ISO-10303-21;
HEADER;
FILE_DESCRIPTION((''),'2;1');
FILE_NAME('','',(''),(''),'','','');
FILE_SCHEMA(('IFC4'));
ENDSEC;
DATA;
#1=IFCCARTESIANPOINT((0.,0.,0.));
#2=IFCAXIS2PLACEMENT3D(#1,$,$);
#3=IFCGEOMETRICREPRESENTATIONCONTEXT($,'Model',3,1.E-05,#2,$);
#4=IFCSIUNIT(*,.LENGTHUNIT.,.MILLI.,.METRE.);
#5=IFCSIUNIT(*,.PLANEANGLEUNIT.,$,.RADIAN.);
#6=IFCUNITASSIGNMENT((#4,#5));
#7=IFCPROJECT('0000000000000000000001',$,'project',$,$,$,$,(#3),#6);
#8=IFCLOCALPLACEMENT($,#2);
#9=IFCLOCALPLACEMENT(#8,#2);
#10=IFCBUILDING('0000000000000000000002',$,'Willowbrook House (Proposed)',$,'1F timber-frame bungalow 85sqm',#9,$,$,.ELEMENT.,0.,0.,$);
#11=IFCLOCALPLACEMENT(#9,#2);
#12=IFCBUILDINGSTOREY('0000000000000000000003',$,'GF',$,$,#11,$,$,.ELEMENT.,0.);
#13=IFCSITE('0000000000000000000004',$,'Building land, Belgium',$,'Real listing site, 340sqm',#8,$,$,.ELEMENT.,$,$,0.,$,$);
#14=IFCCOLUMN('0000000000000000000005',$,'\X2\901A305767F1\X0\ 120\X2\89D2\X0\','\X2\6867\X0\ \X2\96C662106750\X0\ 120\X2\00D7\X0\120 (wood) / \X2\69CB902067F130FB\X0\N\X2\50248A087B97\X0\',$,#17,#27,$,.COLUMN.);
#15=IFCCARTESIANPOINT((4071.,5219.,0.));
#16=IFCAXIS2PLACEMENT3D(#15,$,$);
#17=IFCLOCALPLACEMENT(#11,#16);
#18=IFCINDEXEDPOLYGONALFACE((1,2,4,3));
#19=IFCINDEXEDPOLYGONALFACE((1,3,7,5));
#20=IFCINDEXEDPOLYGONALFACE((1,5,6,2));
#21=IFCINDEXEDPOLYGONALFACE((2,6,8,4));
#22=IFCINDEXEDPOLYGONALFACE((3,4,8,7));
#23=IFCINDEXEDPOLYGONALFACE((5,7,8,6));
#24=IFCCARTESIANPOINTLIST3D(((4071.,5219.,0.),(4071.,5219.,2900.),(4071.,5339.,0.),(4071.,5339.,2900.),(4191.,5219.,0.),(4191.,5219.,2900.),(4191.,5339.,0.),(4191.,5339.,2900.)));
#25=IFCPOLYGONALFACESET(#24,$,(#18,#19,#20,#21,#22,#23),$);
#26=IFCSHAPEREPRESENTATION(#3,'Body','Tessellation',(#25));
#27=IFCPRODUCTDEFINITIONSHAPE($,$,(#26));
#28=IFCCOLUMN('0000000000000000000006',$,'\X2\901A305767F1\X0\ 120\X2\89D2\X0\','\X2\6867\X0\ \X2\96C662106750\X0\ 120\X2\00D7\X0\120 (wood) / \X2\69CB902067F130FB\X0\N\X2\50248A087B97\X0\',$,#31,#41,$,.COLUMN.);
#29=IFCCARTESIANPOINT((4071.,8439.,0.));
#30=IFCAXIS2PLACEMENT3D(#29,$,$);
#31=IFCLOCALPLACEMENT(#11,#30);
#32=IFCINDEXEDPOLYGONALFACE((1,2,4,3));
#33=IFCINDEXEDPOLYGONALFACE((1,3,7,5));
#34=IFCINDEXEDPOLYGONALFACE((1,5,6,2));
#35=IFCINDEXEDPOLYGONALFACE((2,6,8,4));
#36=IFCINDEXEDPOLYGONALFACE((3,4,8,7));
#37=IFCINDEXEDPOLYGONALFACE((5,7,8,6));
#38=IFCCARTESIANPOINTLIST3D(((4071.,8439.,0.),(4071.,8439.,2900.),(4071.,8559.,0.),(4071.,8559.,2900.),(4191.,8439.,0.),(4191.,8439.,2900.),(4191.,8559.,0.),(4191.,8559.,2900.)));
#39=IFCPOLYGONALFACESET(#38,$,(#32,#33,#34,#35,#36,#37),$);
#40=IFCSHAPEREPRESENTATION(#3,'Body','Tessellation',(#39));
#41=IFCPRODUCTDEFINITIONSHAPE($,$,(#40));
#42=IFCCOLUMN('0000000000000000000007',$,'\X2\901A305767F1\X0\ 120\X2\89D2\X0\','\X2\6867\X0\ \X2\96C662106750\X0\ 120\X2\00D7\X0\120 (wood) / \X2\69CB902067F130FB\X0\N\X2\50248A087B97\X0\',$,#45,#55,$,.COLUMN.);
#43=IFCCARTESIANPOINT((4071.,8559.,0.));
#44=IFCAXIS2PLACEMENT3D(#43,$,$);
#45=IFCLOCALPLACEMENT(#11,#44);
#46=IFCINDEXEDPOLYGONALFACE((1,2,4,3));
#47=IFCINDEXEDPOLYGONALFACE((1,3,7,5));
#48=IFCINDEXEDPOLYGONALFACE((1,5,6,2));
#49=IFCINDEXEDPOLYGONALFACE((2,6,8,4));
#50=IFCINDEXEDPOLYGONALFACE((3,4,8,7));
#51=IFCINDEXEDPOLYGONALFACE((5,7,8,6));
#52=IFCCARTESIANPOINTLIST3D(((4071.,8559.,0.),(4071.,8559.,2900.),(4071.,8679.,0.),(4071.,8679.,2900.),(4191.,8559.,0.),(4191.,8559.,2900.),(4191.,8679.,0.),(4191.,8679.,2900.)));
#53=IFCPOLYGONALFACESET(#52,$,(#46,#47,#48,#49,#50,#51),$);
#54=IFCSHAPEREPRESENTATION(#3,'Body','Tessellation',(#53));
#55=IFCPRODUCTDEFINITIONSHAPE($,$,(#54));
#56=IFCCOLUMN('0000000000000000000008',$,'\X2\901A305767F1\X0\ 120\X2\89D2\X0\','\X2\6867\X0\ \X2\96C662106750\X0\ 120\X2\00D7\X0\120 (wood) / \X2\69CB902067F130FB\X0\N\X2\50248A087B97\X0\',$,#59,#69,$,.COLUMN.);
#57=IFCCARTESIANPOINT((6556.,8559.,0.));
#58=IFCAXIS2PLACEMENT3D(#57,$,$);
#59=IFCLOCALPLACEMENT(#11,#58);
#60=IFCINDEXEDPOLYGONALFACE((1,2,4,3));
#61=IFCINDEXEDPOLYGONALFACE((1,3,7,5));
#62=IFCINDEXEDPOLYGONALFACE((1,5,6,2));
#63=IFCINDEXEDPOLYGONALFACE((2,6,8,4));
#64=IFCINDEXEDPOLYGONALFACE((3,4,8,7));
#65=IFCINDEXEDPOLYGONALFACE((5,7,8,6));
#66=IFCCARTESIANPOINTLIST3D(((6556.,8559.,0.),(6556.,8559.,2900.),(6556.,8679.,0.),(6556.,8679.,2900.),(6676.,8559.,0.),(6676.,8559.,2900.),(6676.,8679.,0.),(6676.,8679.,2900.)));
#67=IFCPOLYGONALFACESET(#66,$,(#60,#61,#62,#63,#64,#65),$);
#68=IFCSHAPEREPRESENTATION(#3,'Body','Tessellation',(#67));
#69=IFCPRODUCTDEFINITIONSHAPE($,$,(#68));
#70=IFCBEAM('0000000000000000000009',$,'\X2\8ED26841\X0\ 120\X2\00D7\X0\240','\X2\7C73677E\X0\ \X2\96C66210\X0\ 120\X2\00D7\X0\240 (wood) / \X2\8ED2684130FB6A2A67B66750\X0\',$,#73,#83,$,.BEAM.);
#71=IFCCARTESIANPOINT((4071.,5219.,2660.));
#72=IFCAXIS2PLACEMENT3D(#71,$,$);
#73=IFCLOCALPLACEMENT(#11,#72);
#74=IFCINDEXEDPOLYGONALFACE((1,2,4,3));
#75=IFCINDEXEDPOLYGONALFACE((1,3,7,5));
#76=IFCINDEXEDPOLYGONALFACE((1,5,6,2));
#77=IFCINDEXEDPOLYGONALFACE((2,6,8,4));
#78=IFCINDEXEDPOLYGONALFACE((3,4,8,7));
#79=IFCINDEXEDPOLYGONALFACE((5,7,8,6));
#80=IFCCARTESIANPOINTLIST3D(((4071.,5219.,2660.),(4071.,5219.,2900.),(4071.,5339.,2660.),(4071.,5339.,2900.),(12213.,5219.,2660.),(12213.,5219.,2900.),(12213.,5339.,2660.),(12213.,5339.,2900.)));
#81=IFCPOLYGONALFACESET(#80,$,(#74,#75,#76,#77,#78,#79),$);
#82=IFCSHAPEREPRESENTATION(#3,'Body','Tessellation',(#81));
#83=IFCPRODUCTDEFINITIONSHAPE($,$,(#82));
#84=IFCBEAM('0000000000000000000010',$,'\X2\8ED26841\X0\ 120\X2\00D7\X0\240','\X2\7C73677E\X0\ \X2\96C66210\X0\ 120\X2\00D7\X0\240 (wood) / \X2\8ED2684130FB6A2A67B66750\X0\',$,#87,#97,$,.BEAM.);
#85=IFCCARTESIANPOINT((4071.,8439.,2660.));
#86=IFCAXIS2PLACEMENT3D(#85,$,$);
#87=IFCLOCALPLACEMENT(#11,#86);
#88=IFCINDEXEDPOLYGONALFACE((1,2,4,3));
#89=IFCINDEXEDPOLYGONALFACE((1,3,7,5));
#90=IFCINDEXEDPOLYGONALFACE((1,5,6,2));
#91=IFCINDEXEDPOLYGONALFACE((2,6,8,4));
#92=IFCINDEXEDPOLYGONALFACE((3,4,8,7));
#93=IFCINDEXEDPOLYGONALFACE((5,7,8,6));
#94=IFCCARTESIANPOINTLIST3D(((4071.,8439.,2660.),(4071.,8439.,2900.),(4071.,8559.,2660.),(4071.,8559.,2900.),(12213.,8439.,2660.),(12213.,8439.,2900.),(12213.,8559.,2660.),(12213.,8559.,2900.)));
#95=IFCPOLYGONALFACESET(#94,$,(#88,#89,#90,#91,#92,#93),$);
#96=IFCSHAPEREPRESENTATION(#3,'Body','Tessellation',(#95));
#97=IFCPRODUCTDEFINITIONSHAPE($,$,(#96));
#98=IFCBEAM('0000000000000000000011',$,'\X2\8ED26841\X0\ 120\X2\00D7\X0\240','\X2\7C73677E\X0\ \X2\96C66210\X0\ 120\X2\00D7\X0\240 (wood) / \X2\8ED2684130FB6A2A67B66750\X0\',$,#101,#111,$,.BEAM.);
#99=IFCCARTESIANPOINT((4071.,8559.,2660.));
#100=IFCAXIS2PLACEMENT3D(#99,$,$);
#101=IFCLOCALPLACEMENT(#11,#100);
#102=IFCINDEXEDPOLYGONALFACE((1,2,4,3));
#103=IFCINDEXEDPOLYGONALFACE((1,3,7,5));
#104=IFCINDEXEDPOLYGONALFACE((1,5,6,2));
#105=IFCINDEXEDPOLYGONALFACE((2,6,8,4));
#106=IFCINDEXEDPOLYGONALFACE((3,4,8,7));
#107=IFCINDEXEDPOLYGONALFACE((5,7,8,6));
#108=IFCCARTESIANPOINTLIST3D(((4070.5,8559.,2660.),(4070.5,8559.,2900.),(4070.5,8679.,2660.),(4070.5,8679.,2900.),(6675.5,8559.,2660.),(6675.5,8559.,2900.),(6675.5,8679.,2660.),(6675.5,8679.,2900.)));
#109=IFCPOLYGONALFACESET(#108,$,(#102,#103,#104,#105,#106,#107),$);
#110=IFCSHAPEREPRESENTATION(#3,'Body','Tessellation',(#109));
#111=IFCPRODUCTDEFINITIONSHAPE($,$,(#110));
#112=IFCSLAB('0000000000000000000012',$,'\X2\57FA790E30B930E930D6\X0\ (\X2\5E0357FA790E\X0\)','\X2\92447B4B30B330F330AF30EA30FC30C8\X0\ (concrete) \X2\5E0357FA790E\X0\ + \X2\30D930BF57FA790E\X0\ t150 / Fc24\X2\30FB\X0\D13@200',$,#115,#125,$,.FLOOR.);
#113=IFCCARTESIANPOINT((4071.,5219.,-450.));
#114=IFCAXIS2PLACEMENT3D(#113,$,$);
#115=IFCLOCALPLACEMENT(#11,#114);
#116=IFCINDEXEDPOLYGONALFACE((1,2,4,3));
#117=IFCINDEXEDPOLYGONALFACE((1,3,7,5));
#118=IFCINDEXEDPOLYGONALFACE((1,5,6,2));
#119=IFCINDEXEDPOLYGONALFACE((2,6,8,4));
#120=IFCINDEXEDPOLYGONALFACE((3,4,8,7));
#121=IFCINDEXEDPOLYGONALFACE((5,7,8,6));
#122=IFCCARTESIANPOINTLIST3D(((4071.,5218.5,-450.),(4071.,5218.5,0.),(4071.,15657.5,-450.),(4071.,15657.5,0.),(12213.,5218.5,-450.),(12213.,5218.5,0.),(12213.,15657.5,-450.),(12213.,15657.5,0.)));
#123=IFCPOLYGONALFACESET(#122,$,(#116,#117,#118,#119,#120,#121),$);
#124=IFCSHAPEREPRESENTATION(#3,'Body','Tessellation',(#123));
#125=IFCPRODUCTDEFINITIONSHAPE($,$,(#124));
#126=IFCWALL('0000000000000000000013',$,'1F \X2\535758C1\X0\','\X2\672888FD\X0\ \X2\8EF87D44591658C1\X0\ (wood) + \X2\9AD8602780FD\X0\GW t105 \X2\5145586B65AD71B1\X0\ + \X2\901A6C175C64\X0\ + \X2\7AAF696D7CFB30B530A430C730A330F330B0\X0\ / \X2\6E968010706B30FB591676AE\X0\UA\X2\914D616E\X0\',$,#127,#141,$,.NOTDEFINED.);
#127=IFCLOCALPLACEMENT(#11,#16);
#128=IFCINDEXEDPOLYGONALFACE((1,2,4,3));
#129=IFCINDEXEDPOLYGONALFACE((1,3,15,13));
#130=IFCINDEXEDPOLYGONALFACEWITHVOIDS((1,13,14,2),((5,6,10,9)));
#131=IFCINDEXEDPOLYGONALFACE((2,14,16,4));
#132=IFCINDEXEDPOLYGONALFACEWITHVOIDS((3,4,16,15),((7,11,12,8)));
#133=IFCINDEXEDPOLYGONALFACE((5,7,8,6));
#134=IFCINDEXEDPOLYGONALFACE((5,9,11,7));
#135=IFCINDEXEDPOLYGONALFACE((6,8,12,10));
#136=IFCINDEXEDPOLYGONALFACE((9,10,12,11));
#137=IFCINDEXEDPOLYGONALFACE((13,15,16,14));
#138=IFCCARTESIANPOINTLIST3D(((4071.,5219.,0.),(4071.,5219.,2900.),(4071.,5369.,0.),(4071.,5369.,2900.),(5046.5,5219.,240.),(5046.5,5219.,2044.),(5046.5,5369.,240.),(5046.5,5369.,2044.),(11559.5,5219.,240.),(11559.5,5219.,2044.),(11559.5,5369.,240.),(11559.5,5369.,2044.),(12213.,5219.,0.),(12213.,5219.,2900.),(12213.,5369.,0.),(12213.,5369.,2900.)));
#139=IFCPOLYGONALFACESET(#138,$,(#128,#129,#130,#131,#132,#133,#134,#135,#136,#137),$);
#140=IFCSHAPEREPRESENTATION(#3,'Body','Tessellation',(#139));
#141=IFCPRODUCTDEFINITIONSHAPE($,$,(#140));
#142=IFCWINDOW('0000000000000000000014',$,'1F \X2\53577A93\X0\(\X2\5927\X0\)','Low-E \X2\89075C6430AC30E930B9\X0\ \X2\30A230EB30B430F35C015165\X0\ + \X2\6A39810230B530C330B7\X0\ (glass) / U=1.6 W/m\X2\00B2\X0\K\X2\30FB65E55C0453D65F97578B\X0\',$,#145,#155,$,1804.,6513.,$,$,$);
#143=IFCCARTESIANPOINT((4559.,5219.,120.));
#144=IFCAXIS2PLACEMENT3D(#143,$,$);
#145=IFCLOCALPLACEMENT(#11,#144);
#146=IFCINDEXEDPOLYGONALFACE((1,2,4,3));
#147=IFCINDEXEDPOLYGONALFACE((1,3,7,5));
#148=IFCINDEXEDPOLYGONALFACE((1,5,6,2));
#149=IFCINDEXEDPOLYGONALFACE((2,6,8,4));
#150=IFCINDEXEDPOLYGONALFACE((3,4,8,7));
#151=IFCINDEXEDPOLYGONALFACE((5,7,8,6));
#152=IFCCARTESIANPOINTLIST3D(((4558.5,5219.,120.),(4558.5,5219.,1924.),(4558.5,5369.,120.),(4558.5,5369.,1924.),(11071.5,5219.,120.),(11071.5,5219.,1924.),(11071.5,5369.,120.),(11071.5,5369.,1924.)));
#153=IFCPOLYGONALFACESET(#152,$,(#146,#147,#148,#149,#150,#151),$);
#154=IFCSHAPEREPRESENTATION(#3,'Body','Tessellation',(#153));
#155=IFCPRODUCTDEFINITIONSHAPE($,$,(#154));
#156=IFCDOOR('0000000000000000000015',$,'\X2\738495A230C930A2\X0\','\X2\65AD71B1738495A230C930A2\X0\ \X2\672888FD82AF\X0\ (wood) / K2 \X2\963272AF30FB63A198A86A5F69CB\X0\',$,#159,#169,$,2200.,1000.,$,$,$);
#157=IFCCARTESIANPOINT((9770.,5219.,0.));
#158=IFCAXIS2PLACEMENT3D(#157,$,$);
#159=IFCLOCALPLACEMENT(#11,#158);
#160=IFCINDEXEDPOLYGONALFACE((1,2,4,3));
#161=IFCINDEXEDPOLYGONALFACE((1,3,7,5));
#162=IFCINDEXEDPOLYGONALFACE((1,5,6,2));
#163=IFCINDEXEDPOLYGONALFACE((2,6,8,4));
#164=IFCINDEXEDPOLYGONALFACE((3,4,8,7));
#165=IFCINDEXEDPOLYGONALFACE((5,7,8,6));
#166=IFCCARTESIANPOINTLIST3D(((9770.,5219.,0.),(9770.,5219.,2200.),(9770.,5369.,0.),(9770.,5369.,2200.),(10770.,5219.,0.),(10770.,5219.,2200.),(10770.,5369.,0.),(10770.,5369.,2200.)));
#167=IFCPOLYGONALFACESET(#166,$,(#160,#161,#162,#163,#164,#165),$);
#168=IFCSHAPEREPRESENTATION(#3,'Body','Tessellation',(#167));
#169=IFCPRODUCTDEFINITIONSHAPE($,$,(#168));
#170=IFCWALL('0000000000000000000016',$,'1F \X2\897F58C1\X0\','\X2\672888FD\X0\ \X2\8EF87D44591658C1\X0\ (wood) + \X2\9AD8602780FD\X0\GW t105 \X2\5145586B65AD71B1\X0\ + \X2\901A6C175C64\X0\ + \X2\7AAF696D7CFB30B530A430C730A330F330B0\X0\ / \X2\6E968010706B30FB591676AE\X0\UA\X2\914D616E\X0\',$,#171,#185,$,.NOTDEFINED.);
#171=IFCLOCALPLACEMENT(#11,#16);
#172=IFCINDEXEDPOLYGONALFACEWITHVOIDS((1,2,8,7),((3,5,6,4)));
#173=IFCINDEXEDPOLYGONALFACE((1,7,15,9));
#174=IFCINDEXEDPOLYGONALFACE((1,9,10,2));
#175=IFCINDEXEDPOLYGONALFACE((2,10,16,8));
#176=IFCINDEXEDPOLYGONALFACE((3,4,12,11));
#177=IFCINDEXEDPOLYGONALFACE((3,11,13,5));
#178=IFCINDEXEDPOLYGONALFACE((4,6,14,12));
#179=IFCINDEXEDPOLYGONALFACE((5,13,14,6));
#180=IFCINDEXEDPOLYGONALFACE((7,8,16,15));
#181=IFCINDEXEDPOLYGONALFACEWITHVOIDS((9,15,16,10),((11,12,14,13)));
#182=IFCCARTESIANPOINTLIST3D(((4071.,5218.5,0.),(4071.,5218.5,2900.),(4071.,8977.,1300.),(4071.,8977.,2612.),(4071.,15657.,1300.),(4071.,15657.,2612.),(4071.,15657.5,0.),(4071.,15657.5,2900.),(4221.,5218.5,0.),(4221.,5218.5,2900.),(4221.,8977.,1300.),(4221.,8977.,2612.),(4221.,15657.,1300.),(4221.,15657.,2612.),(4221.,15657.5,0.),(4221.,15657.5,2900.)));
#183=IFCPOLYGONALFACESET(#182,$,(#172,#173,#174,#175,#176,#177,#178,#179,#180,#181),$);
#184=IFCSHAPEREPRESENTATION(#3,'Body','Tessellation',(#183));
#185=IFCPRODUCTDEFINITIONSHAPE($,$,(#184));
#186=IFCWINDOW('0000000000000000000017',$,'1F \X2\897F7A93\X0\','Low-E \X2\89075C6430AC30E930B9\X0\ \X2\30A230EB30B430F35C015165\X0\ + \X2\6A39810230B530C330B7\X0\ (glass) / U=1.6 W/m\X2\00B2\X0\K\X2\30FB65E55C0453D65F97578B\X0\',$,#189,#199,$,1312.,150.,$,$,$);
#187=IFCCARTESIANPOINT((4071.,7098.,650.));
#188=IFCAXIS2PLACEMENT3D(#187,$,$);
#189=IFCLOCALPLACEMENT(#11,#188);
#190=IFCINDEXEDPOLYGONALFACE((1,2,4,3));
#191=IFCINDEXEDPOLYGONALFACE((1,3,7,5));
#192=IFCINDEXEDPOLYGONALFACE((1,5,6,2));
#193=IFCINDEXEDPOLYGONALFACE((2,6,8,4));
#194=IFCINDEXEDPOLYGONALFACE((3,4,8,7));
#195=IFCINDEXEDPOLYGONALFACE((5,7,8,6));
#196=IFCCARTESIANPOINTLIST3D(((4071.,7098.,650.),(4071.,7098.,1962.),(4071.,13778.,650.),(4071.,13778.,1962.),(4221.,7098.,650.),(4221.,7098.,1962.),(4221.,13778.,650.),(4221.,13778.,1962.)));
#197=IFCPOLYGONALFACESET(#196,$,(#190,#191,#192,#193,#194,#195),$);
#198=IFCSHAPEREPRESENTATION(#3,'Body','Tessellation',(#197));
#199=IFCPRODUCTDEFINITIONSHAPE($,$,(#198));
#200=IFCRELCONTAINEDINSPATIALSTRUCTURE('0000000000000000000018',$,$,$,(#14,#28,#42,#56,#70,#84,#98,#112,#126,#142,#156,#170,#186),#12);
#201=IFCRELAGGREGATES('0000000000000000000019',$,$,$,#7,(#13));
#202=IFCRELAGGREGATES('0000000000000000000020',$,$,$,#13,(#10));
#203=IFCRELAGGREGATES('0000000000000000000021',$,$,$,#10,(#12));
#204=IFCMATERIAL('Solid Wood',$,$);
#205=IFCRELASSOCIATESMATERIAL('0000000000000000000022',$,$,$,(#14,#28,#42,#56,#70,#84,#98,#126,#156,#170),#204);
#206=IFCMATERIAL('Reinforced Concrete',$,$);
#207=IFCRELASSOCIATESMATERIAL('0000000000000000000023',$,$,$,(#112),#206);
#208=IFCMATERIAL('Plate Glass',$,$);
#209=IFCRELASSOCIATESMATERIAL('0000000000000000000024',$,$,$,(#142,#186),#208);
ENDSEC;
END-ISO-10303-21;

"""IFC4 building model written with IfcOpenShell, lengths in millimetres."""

from ifc_helpers import new_model, si_unit, frame, frame_2d, origin, place, context, project, spatial, rectangle, extrude, material, element, fill, save


model = new_model("IFC4")

# Units and contexts
model_context = context("Model", 3, precision=1e-05, world=origin())
ifc_project = project(units=[si_unit("LENGTHUNIT", "METRE", prefix="MILLI"), si_unit("PLANEANGLEUNIT", "RADIAN")], contexts=[model_context])

# Site, building, storey
site_placement = place(None, origin())
site = spatial("IfcSite", under=ifc_project, at=site_placement, Name="Building land, Belgium", ObjectType="Real listing site, 340sqm", CompositionType="ELEMENT", RefElevation=0.0)
building_placement = place(site_placement, origin())
building = spatial("IfcBuilding", under=site, at=building_placement, Name="Willowbrook House (Proposed)", ObjectType="1F timber-frame bungalow 85sqm", CompositionType="ELEMENT", ElevationOfRefHeight=0.0, ElevationOfTerrain=0.0)
storey_placement = place(building_placement, origin())
storey = spatial("IfcBuildingStorey", under=building, at=storey_placement, Name="GF", CompositionType="ELEMENT", Elevation=0.0)

# Columns
ifc_material_1 = material(Name="Solid Wood")
column_1_placement = place(storey_placement, frame((4071.0, 5219.0, 0.0)))
element("IfcColumn", 1, at=column_1_placement, inside=storey, material=ifc_material_1, Name="通し柱 120角", Description="桧 集成材 120×120 (wood) / 構造柱・N値計算", PredefinedType="COLUMN", context=model_context, shape_type="SweptSolid", body=[
    extrude(rectangle(XDim=120.0, YDim=120.0, at=frame_2d((60.0, 60.0))), frame((4071.0, 5219.0, 0.0)), (0.0, 0.0, 1.0), 2900.0),
])
column_2_placement = place(storey_placement, frame((4071.0, 8439.0, 0.0)))
element("IfcColumn", 2, at=column_2_placement, inside=storey, material=ifc_material_1, Name="通し柱 120角", Description="桧 集成材 120×120 (wood) / 構造柱・N値計算", PredefinedType="COLUMN", context=model_context, shape_type="SweptSolid", body=[
    extrude(rectangle(XDim=120.0, YDim=120.0, at=frame_2d((60.0, 60.0))), frame((4071.0, 8439.0, 0.0)), (0.0, 0.0, 1.0), 2900.0),
])
column_3_placement = place(storey_placement, frame((4071.0, 8559.0, 0.0)))
element("IfcColumn", 3, at=column_3_placement, inside=storey, material=ifc_material_1, Name="通し柱 120角", Description="桧 集成材 120×120 (wood) / 構造柱・N値計算", PredefinedType="COLUMN", context=model_context, shape_type="SweptSolid", body=[
    extrude(rectangle(XDim=120.0, YDim=120.0, at=frame_2d((60.0, 60.0))), frame((4071.0, 8559.0, 0.0)), (0.0, 0.0, 1.0), 2900.0),
])
column_4_placement = place(storey_placement, frame((6556.0, 8559.0, 0.0)))
element("IfcColumn", 4, at=column_4_placement, inside=storey, material=ifc_material_1, Name="通し柱 120角", Description="桧 集成材 120×120 (wood) / 構造柱・N値計算", PredefinedType="COLUMN", context=model_context, shape_type="SweptSolid", body=[
    extrude(rectangle(XDim=120.0, YDim=120.0, at=frame_2d((60.0, 60.0))), frame((6556.0, 8559.0, 0.0)), (0.0, 0.0, 1.0), 2900.0),
])

# Beams
beam_1_placement = place(storey_placement, frame((4071.0, 5219.0, 2660.0)))
element("IfcBeam", 5, at=beam_1_placement, inside=storey, material=ifc_material_1, Name="軒桁 120×240", Description="米松 集成 120×240 (wood) / 軒桁・横架材", PredefinedType="BEAM", context=model_context, shape_type="SweptSolid", body=[
    extrude(rectangle(XDim=8142.0, YDim=120.0, at=frame_2d((4071.0, 60.0))), frame((4071.0, 5219.0, 2660.0)), (0.0, 0.0, 1.0), 240.0),
])
beam_2_placement = place(storey_placement, frame((4071.0, 8439.0, 2660.0)))
element("IfcBeam", 6, at=beam_2_placement, inside=storey, material=ifc_material_1, Name="軒桁 120×240", Description="米松 集成 120×240 (wood) / 軒桁・横架材", PredefinedType="BEAM", context=model_context, shape_type="SweptSolid", body=[
    extrude(rectangle(XDim=8142.0, YDim=120.0, at=frame_2d((4071.0, 60.0))), frame((4071.0, 8439.0, 2660.0)), (0.0, 0.0, 1.0), 240.0),
])
beam_3_placement = place(storey_placement, frame((4071.0, 8559.0, 2660.0)))
element("IfcBeam", 7, at=beam_3_placement, inside=storey, material=ifc_material_1, Name="軒桁 120×240", Description="米松 集成 120×240 (wood) / 軒桁・横架材", PredefinedType="BEAM", context=model_context, shape_type="SweptSolid", body=[
    extrude(rectangle(XDim=2605.0, YDim=120.0, at=frame_2d((1302.0, 60.0))), frame((4071.0, 8559.0, 2660.0)), (0.0, 0.0, 1.0), 240.0),
])

# Slab
ifc_material_2 = material(Name="Reinforced Concrete")
slab_1_placement = place(storey_placement, frame((4071.0, 5219.0, -450.0)))
element("IfcSlab", 8, at=slab_1_placement, inside=storey, material=ifc_material_2, Name="基礎スラブ (布基礎)", Description="鉄筋コンクリート (concrete) 布基礎 + ベタ基礎 t150 / Fc24・D13@200", PredefinedType="FLOOR", context=model_context, shape_type="SweptSolid", body=[
    extrude(rectangle(XDim=8142.0, YDim=10439.0, at=frame_2d((4071.0, 5219.0))), frame((4071.0, 5219.0, -450.0)), (0.0, 0.0, 1.0), 450.0),
])

# Wall, openings, window, door
wall_1_placement = place(storey_placement, frame((4071.0, 5219.0, 0.0)))
wall_1 = element("IfcWall", 9, at=wall_1_placement, inside=storey, material=ifc_material_1, Name="1F 南壁", Description="木製 軸組外壁 (wood) + 高性能GW t105 充填断熱 + 通気層 + 窯業系サイディング / 準耐火・外皮UA配慮", PredefinedType="NOTDEFINED", context=model_context, shape_type="SweptSolid", body=[
    extrude(rectangle(XDim=8142.0, YDim=150.0, at=frame_2d((4071.0, 75.0))), frame((4071.0, 5219.0, 0.0)), (0.0, 0.0, 1.0), 2900.0),
])
opening_1_placement = place(storey_placement, frame((4559.0, 5219.0, 120.0)))
opening_1 = element("IfcOpeningElement", 10, at=opening_1_placement, cuts=wall_1, PredefinedType="NOTDEFINED", context=model_context, shape_type="SweptSolid", body=[
    extrude(rectangle(XDim=6513.0, YDim=150.0, at=frame_2d((3256.0, 75.0))), frame((4559.0, 5219.0, 120.0)), (0.0, 0.0, 1.0), 1804.0),
])
opening_2_placement = place(storey_placement, frame((9770.0, 5219.0, 0.0)))
opening_2 = element("IfcOpeningElement", 11, at=opening_2_placement, cuts=wall_1, PredefinedType="NOTDEFINED", context=model_context, shape_type="SweptSolid", body=[
    extrude(rectangle(XDim=1000.0, YDim=150.0, at=frame_2d((500.0, 75.0))), frame((9770.0, 5219.0, 0.0)), (0.0, 0.0, 1.0), 2200.0),
])
ifc_material_3 = material(Name="Plate Glass")
window_1_placement = place(storey_placement, frame((4559.0, 5219.0, 120.0)))
window_1 = element("IfcWindow", 12, at=window_1_placement, inside=storey, material=ifc_material_3, Name="1F 南窓(大)", Description="Low-E 複層ガラス アルゴン封入 + 樹脂サッシ (glass) / U=1.6 W/m²K・日射取得型", OverallHeight=1804.0, OverallWidth=6513.0, context=model_context, shape_type="SweptSolid", body=[
    extrude(rectangle(XDim=6513.0, YDim=150.0, at=frame_2d((3256.0, 75.0))), frame((4559.0, 5219.0, 120.0)), (0.0, 0.0, 1.0), 1804.0),
])
fill(opening_1, window_1)
door_placement = place(storey_placement, frame((9770.0, 5219.0, 0.0)))
door = element("IfcDoor", 13, at=door_placement, inside=storey, material=ifc_material_1, Name="玄関ドア", Description="断熱玄関ドア 木製芯 (wood) / K2 防犯・採風機構", OverallHeight=2200.0, OverallWidth=1000.0, context=model_context, shape_type="SweptSolid", body=[
    extrude(rectangle(XDim=1000.0, YDim=150.0, at=frame_2d((500.0, 75.0))), frame((9770.0, 5219.0, 0.0)), (0.0, 0.0, 1.0), 2200.0),
])
fill(opening_2, door)

# Wall, opening, window
wall_2_placement = place(storey_placement, frame((4071.0, 5219.0, 0.0)))
wall_2 = element("IfcWall", 14, at=wall_2_placement, inside=storey, material=ifc_material_1, Name="1F 西壁", Description="木製 軸組外壁 (wood) + 高性能GW t105 充填断熱 + 通気層 + 窯業系サイディング / 準耐火・外皮UA配慮", PredefinedType="NOTDEFINED", context=model_context, shape_type="SweptSolid", body=[
    extrude(rectangle(XDim=150.0, YDim=10439.0, at=frame_2d((75.0, 5219.0))), frame((4071.0, 5219.0, 0.0)), (0.0, 0.0, 1.0), 2900.0),
])
opening_3_placement = place(storey_placement, frame((4071.0, 7098.0, 650.0)))
opening_3 = element("IfcOpeningElement", 15, at=opening_3_placement, cuts=wall_2, PredefinedType="NOTDEFINED", context=model_context, shape_type="SweptSolid", body=[
    extrude(rectangle(XDim=150.0, YDim=6680.0, at=frame_2d((75.0, 3340.0))), frame((4071.0, 7098.0, 650.0)), (0.0, 0.0, 1.0), 1312.0),
])
window_2_placement = place(storey_placement, frame((4071.0, 7098.0, 650.0)))
window_2 = element("IfcWindow", 16, at=window_2_placement, inside=storey, material=ifc_material_3, Name="1F 西窓", Description="Low-E 複層ガラス アルゴン封入 + 樹脂サッシ (glass) / U=1.6 W/m²K・日射取得型", OverallHeight=1312.0, OverallWidth=150.0, context=model_context, shape_type="SweptSolid", body=[
    extrude(rectangle(XDim=150.0, YDim=6680.0, at=frame_2d((75.0, 3340.0))), frame((4071.0, 7098.0, 650.0)), (0.0, 0.0, 1.0), 1312.0),
])
fill(opening_3, window_2)

save(model, "model.ifc")
